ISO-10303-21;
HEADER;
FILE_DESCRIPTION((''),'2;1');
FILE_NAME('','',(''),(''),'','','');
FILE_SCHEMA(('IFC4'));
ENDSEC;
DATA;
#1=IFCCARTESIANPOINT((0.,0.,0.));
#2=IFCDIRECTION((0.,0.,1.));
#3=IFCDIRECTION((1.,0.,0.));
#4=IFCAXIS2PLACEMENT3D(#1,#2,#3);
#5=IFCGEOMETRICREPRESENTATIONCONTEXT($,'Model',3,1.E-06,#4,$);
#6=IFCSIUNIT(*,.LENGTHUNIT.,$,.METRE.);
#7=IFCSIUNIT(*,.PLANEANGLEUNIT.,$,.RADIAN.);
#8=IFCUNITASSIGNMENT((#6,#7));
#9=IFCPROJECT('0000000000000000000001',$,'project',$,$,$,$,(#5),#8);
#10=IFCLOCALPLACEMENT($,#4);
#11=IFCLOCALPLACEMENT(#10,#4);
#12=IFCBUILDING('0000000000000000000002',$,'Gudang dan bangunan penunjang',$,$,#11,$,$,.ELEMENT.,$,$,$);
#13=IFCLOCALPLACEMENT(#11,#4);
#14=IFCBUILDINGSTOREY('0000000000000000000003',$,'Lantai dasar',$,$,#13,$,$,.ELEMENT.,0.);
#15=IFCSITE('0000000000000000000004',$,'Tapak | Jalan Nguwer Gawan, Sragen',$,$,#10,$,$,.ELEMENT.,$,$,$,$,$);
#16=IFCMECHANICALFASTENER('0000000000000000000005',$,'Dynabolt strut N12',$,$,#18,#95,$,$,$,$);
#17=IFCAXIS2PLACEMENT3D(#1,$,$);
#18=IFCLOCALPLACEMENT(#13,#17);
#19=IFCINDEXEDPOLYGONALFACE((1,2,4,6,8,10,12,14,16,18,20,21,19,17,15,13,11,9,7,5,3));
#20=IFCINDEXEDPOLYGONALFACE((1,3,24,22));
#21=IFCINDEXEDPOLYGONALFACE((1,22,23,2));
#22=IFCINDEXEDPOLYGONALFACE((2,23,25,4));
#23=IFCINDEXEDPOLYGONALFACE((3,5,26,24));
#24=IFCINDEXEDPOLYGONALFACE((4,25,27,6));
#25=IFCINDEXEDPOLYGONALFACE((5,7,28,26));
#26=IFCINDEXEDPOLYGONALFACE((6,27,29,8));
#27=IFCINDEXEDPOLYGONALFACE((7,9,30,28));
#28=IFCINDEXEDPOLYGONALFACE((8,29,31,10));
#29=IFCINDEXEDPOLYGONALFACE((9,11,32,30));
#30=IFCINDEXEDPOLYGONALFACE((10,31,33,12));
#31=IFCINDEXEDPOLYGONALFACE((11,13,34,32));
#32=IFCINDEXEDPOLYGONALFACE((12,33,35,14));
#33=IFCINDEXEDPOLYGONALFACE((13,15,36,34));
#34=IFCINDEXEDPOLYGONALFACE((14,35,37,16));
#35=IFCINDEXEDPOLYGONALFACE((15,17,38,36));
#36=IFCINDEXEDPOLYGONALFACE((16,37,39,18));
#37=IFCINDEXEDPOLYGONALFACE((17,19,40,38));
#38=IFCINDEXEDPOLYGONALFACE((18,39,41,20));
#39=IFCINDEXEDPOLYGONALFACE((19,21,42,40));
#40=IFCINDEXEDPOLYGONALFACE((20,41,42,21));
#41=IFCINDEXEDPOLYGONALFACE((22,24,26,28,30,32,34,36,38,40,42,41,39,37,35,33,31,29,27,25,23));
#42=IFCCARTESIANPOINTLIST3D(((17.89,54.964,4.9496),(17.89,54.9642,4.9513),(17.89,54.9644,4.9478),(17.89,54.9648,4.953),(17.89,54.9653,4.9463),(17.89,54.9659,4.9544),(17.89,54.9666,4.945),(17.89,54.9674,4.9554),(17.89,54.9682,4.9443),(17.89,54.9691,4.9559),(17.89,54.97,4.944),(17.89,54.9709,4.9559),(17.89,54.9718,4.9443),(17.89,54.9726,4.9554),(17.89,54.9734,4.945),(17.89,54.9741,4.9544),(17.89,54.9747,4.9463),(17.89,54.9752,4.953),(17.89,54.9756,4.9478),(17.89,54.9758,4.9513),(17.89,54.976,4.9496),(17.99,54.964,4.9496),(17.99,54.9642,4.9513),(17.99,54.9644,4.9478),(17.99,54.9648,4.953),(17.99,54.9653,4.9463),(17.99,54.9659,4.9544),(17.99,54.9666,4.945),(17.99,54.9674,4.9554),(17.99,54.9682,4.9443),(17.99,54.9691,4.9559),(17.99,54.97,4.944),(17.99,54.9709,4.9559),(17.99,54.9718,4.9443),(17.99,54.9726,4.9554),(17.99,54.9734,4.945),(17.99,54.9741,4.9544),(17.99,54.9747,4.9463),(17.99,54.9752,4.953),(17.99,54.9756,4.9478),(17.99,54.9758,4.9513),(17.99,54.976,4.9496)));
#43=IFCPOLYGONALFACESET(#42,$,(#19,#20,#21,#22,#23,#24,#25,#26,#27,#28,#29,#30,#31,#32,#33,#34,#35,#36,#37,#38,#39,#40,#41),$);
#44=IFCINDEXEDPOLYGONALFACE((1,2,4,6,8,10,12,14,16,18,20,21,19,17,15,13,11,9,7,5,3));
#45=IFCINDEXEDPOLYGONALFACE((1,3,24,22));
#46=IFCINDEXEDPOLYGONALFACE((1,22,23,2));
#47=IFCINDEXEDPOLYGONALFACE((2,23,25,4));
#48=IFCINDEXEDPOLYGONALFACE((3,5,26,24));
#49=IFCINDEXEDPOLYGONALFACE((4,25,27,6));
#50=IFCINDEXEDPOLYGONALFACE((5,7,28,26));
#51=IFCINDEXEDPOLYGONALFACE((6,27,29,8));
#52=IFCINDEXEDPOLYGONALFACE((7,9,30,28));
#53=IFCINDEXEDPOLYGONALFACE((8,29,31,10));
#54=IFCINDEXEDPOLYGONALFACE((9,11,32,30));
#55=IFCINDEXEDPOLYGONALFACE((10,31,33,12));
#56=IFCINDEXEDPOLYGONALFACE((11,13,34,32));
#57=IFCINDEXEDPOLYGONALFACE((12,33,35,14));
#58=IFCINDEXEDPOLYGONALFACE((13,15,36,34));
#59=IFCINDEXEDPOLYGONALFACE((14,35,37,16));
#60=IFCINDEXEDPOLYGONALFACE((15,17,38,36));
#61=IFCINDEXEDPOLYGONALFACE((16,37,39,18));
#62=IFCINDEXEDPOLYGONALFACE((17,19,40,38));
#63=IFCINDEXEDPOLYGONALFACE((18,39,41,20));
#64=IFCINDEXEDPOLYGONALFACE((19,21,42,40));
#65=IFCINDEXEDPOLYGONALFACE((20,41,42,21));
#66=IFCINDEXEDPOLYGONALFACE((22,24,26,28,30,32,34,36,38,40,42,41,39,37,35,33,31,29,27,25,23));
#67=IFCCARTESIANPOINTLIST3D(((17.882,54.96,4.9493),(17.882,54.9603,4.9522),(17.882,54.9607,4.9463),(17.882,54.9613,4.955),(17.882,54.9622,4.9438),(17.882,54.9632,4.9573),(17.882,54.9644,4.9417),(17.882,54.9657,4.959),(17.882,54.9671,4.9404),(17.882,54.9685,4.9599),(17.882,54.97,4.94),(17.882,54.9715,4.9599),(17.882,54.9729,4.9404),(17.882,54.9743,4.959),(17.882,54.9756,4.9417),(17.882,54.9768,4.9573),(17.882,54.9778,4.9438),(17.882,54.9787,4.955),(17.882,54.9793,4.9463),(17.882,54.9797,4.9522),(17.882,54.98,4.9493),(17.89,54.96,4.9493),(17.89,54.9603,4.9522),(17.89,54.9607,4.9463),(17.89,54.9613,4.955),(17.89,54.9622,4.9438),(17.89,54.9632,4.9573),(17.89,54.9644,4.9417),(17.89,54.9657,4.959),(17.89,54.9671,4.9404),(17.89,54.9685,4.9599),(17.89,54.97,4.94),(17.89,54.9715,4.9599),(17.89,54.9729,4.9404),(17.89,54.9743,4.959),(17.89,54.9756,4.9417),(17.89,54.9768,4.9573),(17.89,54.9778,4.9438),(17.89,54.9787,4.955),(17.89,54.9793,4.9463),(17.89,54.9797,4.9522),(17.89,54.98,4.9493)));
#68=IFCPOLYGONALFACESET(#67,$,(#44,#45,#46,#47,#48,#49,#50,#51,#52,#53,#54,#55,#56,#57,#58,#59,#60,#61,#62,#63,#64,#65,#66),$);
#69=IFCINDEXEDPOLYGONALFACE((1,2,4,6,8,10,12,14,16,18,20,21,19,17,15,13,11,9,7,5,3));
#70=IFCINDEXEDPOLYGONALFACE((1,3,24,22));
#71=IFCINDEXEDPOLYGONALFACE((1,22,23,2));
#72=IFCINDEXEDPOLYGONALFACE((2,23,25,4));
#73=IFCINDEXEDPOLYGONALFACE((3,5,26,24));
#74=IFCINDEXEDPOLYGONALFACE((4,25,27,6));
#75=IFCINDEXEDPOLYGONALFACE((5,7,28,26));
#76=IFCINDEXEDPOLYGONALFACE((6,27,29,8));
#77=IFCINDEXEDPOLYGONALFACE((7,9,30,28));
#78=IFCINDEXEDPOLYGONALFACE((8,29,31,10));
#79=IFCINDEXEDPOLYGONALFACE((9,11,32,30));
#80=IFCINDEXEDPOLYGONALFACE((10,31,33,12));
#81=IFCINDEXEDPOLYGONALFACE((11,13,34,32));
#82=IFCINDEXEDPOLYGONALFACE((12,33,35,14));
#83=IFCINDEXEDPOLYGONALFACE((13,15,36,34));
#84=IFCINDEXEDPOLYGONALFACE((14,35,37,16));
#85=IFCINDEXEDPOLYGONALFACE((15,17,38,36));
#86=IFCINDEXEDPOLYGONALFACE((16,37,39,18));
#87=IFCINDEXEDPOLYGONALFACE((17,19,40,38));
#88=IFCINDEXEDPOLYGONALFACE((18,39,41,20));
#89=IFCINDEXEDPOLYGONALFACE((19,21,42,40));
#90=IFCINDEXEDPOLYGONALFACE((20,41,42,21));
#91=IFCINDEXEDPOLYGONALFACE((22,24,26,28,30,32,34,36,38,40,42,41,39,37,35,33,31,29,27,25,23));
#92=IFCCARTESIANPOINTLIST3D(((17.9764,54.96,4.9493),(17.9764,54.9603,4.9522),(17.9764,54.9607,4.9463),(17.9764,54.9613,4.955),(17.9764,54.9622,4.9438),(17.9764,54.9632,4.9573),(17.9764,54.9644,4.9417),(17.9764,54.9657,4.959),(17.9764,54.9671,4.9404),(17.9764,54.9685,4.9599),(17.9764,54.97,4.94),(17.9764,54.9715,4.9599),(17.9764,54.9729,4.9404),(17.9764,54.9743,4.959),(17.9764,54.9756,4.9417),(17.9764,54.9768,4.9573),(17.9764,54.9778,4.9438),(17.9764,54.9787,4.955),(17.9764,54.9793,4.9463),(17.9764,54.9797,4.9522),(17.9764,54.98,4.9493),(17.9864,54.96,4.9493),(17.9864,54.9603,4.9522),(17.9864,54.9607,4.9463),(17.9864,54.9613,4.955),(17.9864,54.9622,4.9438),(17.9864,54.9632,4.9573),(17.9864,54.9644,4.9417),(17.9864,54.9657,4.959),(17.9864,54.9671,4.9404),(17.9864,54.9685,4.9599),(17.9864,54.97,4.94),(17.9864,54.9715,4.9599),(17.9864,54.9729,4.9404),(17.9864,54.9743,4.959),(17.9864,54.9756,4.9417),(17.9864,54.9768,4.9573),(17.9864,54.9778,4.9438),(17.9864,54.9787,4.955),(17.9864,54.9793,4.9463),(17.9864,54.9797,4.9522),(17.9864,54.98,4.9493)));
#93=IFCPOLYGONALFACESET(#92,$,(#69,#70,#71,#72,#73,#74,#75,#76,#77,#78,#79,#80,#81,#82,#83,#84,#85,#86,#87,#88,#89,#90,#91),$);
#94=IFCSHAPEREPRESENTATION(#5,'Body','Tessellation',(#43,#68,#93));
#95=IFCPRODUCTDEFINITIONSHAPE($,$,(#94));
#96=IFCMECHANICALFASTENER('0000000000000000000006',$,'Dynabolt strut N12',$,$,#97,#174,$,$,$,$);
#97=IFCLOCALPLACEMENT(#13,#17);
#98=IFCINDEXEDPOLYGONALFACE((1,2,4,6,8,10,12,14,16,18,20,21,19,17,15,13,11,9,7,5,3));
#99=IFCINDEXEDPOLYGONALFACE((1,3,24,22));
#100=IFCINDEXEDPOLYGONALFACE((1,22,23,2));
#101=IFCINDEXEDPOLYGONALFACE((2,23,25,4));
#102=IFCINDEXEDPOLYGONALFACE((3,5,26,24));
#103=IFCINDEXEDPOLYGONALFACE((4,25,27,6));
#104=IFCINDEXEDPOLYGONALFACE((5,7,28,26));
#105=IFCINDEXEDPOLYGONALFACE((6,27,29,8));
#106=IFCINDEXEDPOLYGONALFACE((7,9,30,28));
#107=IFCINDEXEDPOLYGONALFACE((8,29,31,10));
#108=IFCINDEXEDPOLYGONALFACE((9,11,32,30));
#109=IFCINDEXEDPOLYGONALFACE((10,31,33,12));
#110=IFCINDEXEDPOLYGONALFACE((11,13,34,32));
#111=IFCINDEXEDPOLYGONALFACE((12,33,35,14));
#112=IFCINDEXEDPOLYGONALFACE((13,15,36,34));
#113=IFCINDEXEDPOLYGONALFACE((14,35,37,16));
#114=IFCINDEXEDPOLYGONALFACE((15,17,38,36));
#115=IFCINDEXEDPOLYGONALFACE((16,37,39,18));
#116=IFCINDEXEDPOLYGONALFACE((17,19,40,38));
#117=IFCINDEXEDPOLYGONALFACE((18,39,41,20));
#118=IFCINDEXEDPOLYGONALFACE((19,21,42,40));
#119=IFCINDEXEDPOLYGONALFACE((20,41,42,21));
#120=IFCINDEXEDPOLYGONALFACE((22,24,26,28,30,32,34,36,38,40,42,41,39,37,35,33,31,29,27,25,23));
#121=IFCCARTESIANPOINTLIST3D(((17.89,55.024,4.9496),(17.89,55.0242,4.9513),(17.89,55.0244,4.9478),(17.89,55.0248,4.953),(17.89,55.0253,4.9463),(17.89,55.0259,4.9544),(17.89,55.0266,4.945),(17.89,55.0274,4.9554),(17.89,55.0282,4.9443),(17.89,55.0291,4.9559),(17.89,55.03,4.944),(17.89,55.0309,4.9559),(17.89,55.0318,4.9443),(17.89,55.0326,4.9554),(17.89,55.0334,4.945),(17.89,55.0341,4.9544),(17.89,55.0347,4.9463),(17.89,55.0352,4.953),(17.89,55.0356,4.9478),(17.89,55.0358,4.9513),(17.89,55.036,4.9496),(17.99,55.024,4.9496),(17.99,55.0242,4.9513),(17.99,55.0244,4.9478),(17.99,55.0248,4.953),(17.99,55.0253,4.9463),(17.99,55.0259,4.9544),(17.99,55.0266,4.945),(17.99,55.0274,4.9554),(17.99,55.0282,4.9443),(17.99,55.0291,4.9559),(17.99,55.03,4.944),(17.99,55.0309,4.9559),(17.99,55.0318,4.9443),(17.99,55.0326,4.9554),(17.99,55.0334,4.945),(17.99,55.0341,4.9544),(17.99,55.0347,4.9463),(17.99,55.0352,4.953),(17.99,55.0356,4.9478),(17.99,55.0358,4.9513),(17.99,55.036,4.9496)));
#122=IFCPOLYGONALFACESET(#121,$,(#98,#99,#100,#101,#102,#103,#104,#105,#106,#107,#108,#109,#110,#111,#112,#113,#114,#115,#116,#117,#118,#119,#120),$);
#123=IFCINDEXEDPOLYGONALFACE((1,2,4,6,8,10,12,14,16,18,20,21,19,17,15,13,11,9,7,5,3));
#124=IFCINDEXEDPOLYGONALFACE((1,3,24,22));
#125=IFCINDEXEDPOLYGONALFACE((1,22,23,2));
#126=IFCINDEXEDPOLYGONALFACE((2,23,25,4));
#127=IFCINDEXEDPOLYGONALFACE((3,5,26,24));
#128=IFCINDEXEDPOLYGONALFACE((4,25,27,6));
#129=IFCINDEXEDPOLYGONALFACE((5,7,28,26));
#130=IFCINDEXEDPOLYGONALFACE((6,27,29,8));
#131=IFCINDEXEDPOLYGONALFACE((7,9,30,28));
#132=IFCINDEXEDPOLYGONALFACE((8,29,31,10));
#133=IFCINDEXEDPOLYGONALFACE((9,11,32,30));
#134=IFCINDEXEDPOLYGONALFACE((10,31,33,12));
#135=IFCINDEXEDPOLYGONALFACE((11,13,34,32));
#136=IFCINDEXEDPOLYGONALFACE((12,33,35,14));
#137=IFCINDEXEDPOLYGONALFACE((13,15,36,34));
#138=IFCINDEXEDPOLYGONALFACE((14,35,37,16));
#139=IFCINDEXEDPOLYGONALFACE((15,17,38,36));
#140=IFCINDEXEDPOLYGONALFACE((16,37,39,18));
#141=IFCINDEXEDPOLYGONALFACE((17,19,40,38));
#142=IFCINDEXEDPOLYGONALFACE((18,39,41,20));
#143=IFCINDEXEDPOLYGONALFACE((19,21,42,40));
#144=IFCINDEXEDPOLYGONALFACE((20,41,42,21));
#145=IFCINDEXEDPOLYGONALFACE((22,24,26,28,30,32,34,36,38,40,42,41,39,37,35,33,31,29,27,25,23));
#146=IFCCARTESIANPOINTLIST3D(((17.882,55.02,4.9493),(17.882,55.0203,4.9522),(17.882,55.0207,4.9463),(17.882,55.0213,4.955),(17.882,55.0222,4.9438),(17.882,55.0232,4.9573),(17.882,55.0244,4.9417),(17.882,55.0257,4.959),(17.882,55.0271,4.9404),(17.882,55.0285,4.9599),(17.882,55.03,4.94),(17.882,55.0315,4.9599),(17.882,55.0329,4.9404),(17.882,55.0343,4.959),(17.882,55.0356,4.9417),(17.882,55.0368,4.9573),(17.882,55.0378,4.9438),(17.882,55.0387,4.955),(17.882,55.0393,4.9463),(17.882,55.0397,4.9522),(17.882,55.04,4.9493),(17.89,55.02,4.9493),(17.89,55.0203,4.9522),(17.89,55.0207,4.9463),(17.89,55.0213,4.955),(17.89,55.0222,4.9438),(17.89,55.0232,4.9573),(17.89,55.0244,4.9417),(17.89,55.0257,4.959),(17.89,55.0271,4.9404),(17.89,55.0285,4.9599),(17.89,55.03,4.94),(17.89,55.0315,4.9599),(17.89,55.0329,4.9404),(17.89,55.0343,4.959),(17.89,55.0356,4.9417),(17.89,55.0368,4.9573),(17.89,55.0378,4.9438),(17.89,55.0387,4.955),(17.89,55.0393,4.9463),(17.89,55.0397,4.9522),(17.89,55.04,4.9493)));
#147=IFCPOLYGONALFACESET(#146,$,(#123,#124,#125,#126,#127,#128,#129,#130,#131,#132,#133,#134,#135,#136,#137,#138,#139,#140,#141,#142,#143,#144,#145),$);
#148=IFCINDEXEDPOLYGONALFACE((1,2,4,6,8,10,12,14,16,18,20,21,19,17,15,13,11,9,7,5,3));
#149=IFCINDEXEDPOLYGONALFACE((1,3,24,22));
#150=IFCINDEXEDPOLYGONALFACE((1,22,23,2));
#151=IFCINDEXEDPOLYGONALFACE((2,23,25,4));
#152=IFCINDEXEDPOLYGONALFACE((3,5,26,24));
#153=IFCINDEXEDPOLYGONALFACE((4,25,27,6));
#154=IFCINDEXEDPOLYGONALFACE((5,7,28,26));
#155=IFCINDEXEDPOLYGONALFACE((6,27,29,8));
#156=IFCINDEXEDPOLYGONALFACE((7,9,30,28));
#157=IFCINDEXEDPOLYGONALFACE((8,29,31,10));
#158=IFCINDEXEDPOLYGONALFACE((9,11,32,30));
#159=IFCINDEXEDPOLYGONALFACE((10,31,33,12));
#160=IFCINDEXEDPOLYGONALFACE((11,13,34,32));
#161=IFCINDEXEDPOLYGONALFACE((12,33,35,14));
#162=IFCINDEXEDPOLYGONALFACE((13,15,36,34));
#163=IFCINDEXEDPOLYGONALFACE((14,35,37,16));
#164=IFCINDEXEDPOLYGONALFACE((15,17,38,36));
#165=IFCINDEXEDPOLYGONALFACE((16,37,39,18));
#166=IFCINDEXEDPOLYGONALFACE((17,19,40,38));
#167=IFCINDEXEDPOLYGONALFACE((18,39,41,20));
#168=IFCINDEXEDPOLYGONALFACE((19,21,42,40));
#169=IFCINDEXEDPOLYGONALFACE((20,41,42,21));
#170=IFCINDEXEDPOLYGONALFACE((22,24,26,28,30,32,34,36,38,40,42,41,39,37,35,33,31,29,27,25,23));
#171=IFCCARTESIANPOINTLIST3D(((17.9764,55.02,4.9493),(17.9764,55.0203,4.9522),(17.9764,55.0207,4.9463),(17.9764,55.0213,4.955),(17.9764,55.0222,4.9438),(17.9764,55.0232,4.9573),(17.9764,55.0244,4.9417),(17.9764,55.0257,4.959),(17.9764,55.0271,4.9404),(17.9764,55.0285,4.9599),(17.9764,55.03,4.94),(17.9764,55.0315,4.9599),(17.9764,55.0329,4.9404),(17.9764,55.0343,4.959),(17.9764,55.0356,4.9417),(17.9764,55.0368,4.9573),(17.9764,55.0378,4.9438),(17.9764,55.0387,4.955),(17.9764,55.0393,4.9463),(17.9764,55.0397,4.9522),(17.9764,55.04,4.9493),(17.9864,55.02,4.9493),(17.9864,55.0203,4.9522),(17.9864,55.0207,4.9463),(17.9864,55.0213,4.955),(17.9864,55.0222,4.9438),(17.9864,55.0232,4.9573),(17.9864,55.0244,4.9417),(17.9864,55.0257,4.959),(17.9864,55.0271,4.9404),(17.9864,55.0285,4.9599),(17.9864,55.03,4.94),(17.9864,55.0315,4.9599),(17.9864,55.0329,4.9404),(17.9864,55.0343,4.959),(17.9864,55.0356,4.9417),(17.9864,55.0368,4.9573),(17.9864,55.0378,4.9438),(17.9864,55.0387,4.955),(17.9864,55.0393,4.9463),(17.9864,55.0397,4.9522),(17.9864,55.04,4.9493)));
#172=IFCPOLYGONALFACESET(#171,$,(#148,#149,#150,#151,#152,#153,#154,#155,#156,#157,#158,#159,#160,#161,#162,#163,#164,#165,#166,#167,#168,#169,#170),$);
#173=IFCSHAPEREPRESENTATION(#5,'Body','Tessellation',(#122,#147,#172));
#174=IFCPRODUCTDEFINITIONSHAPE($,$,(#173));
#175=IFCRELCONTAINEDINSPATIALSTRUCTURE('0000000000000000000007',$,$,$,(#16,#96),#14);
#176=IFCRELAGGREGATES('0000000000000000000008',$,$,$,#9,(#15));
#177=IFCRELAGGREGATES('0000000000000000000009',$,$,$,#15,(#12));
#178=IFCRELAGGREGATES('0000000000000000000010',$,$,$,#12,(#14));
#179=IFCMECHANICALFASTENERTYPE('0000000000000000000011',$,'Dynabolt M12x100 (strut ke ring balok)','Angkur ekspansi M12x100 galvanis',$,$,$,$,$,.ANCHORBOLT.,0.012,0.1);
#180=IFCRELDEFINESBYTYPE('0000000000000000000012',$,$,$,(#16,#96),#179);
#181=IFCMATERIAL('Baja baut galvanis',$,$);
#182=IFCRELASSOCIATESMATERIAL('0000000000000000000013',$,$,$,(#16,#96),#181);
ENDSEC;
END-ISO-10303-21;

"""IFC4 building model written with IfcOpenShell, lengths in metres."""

from ifc_helpers import new_model, si_unit, frame, origin_with_axes, place, context, project, spatial, circle, extrude, source, transform, mapped, material, type_object, type_shapes, element, save


model = new_model("IFC4")

# Units and contexts
model_context = context("Model", 3, precision=1e-06, world=origin_with_axes())
ifc_project = project(units=[si_unit("LENGTHUNIT", "METRE"), si_unit("PLANEANGLEUNIT", "RADIAN")], contexts=[model_context])

# Site, building, storey
site_placement = place(None, origin_with_axes())
site = spatial("IfcSite", under=ifc_project, at=site_placement, Name="Tapak | Jalan Nguwer Gawan, Sragen", CompositionType="ELEMENT")
building_placement = place(site_placement, origin_with_axes())
building = spatial("IfcBuilding", under=site, at=building_placement, Name="Gudang dan bangunan penunjang", CompositionType="ELEMENT")
storey_placement = place(building_placement, origin_with_axes())
storey = spatial("IfcBuildingStorey", under=building, at=storey_placement, Name="Lantai dasar", CompositionType="ELEMENT", Elevation=0.0)

# Mechanical fasteners
ifc_material = material(Name="Baja baut galvanis")
mechanical_fastener_type = type_object("IfcMechanicalFastenerType", Name="Dynabolt M12x100 (strut ke ring balok)", Description="Angkur ekspansi M12x100 galvanis", NominalDiameter=0.012, NominalLength=0.1, PredefinedType="ANCHORBOLT")
shared_shape = source(origin_with_axes(), model_context, "Body", "SweptSolid", [
    extrude(circle(Radius=0.006), origin_with_axes(), (0.0, 0.0, 1.0), 0.1),
    extrude(circle(Radius=0.01), frame((0.0, 0.0, -0.008), z_axis=(0.0, 0.0, 1.0), x_axis=(1.0, 0.0, 0.0)), (0.0, 0.0, 1.0), 0.008),
    extrude(circle(Radius=0.01), frame((0.0, 0.0, 0.0864), z_axis=(0.0, 0.0, 1.0), x_axis=(1.0, 0.0, 0.0)), (0.0, 0.0, 1.0), 0.01),
])
type_shapes(mechanical_fastener_type, [shared_shape])
placement = place(None, origin_with_axes())
element("IfcMechanicalFastener", 1, at=placement, inside=storey, type_object=mechanical_fastener_type, material=ifc_material, Name="Dynabolt strut N12", context=model_context, shape_type="MappedRepresentation", body=[
    mapped(shared_shape, transform((17.89, 54.97, 4.95), x_axis=(0.0, 0.0, -1.0), y_axis=(0.0, 1.0, 0.0), z_axis=(1.0, 0.0, 0.0), scale=1.0)),
])
element("IfcMechanicalFastener", 2, at=placement, inside=storey, type_object=mechanical_fastener_type, material=ifc_material, Name="Dynabolt strut N12", context=model_context, shape_type="MappedRepresentation", body=[
    mapped(shared_shape, transform((17.89, 55.03, 4.95), x_axis=(0.0, 0.0, -1.0), y_axis=(0.0, 1.0, 0.0), z_axis=(1.0, 0.0, 0.0), scale=1.0)),
])

save(model, "model.ifc")
